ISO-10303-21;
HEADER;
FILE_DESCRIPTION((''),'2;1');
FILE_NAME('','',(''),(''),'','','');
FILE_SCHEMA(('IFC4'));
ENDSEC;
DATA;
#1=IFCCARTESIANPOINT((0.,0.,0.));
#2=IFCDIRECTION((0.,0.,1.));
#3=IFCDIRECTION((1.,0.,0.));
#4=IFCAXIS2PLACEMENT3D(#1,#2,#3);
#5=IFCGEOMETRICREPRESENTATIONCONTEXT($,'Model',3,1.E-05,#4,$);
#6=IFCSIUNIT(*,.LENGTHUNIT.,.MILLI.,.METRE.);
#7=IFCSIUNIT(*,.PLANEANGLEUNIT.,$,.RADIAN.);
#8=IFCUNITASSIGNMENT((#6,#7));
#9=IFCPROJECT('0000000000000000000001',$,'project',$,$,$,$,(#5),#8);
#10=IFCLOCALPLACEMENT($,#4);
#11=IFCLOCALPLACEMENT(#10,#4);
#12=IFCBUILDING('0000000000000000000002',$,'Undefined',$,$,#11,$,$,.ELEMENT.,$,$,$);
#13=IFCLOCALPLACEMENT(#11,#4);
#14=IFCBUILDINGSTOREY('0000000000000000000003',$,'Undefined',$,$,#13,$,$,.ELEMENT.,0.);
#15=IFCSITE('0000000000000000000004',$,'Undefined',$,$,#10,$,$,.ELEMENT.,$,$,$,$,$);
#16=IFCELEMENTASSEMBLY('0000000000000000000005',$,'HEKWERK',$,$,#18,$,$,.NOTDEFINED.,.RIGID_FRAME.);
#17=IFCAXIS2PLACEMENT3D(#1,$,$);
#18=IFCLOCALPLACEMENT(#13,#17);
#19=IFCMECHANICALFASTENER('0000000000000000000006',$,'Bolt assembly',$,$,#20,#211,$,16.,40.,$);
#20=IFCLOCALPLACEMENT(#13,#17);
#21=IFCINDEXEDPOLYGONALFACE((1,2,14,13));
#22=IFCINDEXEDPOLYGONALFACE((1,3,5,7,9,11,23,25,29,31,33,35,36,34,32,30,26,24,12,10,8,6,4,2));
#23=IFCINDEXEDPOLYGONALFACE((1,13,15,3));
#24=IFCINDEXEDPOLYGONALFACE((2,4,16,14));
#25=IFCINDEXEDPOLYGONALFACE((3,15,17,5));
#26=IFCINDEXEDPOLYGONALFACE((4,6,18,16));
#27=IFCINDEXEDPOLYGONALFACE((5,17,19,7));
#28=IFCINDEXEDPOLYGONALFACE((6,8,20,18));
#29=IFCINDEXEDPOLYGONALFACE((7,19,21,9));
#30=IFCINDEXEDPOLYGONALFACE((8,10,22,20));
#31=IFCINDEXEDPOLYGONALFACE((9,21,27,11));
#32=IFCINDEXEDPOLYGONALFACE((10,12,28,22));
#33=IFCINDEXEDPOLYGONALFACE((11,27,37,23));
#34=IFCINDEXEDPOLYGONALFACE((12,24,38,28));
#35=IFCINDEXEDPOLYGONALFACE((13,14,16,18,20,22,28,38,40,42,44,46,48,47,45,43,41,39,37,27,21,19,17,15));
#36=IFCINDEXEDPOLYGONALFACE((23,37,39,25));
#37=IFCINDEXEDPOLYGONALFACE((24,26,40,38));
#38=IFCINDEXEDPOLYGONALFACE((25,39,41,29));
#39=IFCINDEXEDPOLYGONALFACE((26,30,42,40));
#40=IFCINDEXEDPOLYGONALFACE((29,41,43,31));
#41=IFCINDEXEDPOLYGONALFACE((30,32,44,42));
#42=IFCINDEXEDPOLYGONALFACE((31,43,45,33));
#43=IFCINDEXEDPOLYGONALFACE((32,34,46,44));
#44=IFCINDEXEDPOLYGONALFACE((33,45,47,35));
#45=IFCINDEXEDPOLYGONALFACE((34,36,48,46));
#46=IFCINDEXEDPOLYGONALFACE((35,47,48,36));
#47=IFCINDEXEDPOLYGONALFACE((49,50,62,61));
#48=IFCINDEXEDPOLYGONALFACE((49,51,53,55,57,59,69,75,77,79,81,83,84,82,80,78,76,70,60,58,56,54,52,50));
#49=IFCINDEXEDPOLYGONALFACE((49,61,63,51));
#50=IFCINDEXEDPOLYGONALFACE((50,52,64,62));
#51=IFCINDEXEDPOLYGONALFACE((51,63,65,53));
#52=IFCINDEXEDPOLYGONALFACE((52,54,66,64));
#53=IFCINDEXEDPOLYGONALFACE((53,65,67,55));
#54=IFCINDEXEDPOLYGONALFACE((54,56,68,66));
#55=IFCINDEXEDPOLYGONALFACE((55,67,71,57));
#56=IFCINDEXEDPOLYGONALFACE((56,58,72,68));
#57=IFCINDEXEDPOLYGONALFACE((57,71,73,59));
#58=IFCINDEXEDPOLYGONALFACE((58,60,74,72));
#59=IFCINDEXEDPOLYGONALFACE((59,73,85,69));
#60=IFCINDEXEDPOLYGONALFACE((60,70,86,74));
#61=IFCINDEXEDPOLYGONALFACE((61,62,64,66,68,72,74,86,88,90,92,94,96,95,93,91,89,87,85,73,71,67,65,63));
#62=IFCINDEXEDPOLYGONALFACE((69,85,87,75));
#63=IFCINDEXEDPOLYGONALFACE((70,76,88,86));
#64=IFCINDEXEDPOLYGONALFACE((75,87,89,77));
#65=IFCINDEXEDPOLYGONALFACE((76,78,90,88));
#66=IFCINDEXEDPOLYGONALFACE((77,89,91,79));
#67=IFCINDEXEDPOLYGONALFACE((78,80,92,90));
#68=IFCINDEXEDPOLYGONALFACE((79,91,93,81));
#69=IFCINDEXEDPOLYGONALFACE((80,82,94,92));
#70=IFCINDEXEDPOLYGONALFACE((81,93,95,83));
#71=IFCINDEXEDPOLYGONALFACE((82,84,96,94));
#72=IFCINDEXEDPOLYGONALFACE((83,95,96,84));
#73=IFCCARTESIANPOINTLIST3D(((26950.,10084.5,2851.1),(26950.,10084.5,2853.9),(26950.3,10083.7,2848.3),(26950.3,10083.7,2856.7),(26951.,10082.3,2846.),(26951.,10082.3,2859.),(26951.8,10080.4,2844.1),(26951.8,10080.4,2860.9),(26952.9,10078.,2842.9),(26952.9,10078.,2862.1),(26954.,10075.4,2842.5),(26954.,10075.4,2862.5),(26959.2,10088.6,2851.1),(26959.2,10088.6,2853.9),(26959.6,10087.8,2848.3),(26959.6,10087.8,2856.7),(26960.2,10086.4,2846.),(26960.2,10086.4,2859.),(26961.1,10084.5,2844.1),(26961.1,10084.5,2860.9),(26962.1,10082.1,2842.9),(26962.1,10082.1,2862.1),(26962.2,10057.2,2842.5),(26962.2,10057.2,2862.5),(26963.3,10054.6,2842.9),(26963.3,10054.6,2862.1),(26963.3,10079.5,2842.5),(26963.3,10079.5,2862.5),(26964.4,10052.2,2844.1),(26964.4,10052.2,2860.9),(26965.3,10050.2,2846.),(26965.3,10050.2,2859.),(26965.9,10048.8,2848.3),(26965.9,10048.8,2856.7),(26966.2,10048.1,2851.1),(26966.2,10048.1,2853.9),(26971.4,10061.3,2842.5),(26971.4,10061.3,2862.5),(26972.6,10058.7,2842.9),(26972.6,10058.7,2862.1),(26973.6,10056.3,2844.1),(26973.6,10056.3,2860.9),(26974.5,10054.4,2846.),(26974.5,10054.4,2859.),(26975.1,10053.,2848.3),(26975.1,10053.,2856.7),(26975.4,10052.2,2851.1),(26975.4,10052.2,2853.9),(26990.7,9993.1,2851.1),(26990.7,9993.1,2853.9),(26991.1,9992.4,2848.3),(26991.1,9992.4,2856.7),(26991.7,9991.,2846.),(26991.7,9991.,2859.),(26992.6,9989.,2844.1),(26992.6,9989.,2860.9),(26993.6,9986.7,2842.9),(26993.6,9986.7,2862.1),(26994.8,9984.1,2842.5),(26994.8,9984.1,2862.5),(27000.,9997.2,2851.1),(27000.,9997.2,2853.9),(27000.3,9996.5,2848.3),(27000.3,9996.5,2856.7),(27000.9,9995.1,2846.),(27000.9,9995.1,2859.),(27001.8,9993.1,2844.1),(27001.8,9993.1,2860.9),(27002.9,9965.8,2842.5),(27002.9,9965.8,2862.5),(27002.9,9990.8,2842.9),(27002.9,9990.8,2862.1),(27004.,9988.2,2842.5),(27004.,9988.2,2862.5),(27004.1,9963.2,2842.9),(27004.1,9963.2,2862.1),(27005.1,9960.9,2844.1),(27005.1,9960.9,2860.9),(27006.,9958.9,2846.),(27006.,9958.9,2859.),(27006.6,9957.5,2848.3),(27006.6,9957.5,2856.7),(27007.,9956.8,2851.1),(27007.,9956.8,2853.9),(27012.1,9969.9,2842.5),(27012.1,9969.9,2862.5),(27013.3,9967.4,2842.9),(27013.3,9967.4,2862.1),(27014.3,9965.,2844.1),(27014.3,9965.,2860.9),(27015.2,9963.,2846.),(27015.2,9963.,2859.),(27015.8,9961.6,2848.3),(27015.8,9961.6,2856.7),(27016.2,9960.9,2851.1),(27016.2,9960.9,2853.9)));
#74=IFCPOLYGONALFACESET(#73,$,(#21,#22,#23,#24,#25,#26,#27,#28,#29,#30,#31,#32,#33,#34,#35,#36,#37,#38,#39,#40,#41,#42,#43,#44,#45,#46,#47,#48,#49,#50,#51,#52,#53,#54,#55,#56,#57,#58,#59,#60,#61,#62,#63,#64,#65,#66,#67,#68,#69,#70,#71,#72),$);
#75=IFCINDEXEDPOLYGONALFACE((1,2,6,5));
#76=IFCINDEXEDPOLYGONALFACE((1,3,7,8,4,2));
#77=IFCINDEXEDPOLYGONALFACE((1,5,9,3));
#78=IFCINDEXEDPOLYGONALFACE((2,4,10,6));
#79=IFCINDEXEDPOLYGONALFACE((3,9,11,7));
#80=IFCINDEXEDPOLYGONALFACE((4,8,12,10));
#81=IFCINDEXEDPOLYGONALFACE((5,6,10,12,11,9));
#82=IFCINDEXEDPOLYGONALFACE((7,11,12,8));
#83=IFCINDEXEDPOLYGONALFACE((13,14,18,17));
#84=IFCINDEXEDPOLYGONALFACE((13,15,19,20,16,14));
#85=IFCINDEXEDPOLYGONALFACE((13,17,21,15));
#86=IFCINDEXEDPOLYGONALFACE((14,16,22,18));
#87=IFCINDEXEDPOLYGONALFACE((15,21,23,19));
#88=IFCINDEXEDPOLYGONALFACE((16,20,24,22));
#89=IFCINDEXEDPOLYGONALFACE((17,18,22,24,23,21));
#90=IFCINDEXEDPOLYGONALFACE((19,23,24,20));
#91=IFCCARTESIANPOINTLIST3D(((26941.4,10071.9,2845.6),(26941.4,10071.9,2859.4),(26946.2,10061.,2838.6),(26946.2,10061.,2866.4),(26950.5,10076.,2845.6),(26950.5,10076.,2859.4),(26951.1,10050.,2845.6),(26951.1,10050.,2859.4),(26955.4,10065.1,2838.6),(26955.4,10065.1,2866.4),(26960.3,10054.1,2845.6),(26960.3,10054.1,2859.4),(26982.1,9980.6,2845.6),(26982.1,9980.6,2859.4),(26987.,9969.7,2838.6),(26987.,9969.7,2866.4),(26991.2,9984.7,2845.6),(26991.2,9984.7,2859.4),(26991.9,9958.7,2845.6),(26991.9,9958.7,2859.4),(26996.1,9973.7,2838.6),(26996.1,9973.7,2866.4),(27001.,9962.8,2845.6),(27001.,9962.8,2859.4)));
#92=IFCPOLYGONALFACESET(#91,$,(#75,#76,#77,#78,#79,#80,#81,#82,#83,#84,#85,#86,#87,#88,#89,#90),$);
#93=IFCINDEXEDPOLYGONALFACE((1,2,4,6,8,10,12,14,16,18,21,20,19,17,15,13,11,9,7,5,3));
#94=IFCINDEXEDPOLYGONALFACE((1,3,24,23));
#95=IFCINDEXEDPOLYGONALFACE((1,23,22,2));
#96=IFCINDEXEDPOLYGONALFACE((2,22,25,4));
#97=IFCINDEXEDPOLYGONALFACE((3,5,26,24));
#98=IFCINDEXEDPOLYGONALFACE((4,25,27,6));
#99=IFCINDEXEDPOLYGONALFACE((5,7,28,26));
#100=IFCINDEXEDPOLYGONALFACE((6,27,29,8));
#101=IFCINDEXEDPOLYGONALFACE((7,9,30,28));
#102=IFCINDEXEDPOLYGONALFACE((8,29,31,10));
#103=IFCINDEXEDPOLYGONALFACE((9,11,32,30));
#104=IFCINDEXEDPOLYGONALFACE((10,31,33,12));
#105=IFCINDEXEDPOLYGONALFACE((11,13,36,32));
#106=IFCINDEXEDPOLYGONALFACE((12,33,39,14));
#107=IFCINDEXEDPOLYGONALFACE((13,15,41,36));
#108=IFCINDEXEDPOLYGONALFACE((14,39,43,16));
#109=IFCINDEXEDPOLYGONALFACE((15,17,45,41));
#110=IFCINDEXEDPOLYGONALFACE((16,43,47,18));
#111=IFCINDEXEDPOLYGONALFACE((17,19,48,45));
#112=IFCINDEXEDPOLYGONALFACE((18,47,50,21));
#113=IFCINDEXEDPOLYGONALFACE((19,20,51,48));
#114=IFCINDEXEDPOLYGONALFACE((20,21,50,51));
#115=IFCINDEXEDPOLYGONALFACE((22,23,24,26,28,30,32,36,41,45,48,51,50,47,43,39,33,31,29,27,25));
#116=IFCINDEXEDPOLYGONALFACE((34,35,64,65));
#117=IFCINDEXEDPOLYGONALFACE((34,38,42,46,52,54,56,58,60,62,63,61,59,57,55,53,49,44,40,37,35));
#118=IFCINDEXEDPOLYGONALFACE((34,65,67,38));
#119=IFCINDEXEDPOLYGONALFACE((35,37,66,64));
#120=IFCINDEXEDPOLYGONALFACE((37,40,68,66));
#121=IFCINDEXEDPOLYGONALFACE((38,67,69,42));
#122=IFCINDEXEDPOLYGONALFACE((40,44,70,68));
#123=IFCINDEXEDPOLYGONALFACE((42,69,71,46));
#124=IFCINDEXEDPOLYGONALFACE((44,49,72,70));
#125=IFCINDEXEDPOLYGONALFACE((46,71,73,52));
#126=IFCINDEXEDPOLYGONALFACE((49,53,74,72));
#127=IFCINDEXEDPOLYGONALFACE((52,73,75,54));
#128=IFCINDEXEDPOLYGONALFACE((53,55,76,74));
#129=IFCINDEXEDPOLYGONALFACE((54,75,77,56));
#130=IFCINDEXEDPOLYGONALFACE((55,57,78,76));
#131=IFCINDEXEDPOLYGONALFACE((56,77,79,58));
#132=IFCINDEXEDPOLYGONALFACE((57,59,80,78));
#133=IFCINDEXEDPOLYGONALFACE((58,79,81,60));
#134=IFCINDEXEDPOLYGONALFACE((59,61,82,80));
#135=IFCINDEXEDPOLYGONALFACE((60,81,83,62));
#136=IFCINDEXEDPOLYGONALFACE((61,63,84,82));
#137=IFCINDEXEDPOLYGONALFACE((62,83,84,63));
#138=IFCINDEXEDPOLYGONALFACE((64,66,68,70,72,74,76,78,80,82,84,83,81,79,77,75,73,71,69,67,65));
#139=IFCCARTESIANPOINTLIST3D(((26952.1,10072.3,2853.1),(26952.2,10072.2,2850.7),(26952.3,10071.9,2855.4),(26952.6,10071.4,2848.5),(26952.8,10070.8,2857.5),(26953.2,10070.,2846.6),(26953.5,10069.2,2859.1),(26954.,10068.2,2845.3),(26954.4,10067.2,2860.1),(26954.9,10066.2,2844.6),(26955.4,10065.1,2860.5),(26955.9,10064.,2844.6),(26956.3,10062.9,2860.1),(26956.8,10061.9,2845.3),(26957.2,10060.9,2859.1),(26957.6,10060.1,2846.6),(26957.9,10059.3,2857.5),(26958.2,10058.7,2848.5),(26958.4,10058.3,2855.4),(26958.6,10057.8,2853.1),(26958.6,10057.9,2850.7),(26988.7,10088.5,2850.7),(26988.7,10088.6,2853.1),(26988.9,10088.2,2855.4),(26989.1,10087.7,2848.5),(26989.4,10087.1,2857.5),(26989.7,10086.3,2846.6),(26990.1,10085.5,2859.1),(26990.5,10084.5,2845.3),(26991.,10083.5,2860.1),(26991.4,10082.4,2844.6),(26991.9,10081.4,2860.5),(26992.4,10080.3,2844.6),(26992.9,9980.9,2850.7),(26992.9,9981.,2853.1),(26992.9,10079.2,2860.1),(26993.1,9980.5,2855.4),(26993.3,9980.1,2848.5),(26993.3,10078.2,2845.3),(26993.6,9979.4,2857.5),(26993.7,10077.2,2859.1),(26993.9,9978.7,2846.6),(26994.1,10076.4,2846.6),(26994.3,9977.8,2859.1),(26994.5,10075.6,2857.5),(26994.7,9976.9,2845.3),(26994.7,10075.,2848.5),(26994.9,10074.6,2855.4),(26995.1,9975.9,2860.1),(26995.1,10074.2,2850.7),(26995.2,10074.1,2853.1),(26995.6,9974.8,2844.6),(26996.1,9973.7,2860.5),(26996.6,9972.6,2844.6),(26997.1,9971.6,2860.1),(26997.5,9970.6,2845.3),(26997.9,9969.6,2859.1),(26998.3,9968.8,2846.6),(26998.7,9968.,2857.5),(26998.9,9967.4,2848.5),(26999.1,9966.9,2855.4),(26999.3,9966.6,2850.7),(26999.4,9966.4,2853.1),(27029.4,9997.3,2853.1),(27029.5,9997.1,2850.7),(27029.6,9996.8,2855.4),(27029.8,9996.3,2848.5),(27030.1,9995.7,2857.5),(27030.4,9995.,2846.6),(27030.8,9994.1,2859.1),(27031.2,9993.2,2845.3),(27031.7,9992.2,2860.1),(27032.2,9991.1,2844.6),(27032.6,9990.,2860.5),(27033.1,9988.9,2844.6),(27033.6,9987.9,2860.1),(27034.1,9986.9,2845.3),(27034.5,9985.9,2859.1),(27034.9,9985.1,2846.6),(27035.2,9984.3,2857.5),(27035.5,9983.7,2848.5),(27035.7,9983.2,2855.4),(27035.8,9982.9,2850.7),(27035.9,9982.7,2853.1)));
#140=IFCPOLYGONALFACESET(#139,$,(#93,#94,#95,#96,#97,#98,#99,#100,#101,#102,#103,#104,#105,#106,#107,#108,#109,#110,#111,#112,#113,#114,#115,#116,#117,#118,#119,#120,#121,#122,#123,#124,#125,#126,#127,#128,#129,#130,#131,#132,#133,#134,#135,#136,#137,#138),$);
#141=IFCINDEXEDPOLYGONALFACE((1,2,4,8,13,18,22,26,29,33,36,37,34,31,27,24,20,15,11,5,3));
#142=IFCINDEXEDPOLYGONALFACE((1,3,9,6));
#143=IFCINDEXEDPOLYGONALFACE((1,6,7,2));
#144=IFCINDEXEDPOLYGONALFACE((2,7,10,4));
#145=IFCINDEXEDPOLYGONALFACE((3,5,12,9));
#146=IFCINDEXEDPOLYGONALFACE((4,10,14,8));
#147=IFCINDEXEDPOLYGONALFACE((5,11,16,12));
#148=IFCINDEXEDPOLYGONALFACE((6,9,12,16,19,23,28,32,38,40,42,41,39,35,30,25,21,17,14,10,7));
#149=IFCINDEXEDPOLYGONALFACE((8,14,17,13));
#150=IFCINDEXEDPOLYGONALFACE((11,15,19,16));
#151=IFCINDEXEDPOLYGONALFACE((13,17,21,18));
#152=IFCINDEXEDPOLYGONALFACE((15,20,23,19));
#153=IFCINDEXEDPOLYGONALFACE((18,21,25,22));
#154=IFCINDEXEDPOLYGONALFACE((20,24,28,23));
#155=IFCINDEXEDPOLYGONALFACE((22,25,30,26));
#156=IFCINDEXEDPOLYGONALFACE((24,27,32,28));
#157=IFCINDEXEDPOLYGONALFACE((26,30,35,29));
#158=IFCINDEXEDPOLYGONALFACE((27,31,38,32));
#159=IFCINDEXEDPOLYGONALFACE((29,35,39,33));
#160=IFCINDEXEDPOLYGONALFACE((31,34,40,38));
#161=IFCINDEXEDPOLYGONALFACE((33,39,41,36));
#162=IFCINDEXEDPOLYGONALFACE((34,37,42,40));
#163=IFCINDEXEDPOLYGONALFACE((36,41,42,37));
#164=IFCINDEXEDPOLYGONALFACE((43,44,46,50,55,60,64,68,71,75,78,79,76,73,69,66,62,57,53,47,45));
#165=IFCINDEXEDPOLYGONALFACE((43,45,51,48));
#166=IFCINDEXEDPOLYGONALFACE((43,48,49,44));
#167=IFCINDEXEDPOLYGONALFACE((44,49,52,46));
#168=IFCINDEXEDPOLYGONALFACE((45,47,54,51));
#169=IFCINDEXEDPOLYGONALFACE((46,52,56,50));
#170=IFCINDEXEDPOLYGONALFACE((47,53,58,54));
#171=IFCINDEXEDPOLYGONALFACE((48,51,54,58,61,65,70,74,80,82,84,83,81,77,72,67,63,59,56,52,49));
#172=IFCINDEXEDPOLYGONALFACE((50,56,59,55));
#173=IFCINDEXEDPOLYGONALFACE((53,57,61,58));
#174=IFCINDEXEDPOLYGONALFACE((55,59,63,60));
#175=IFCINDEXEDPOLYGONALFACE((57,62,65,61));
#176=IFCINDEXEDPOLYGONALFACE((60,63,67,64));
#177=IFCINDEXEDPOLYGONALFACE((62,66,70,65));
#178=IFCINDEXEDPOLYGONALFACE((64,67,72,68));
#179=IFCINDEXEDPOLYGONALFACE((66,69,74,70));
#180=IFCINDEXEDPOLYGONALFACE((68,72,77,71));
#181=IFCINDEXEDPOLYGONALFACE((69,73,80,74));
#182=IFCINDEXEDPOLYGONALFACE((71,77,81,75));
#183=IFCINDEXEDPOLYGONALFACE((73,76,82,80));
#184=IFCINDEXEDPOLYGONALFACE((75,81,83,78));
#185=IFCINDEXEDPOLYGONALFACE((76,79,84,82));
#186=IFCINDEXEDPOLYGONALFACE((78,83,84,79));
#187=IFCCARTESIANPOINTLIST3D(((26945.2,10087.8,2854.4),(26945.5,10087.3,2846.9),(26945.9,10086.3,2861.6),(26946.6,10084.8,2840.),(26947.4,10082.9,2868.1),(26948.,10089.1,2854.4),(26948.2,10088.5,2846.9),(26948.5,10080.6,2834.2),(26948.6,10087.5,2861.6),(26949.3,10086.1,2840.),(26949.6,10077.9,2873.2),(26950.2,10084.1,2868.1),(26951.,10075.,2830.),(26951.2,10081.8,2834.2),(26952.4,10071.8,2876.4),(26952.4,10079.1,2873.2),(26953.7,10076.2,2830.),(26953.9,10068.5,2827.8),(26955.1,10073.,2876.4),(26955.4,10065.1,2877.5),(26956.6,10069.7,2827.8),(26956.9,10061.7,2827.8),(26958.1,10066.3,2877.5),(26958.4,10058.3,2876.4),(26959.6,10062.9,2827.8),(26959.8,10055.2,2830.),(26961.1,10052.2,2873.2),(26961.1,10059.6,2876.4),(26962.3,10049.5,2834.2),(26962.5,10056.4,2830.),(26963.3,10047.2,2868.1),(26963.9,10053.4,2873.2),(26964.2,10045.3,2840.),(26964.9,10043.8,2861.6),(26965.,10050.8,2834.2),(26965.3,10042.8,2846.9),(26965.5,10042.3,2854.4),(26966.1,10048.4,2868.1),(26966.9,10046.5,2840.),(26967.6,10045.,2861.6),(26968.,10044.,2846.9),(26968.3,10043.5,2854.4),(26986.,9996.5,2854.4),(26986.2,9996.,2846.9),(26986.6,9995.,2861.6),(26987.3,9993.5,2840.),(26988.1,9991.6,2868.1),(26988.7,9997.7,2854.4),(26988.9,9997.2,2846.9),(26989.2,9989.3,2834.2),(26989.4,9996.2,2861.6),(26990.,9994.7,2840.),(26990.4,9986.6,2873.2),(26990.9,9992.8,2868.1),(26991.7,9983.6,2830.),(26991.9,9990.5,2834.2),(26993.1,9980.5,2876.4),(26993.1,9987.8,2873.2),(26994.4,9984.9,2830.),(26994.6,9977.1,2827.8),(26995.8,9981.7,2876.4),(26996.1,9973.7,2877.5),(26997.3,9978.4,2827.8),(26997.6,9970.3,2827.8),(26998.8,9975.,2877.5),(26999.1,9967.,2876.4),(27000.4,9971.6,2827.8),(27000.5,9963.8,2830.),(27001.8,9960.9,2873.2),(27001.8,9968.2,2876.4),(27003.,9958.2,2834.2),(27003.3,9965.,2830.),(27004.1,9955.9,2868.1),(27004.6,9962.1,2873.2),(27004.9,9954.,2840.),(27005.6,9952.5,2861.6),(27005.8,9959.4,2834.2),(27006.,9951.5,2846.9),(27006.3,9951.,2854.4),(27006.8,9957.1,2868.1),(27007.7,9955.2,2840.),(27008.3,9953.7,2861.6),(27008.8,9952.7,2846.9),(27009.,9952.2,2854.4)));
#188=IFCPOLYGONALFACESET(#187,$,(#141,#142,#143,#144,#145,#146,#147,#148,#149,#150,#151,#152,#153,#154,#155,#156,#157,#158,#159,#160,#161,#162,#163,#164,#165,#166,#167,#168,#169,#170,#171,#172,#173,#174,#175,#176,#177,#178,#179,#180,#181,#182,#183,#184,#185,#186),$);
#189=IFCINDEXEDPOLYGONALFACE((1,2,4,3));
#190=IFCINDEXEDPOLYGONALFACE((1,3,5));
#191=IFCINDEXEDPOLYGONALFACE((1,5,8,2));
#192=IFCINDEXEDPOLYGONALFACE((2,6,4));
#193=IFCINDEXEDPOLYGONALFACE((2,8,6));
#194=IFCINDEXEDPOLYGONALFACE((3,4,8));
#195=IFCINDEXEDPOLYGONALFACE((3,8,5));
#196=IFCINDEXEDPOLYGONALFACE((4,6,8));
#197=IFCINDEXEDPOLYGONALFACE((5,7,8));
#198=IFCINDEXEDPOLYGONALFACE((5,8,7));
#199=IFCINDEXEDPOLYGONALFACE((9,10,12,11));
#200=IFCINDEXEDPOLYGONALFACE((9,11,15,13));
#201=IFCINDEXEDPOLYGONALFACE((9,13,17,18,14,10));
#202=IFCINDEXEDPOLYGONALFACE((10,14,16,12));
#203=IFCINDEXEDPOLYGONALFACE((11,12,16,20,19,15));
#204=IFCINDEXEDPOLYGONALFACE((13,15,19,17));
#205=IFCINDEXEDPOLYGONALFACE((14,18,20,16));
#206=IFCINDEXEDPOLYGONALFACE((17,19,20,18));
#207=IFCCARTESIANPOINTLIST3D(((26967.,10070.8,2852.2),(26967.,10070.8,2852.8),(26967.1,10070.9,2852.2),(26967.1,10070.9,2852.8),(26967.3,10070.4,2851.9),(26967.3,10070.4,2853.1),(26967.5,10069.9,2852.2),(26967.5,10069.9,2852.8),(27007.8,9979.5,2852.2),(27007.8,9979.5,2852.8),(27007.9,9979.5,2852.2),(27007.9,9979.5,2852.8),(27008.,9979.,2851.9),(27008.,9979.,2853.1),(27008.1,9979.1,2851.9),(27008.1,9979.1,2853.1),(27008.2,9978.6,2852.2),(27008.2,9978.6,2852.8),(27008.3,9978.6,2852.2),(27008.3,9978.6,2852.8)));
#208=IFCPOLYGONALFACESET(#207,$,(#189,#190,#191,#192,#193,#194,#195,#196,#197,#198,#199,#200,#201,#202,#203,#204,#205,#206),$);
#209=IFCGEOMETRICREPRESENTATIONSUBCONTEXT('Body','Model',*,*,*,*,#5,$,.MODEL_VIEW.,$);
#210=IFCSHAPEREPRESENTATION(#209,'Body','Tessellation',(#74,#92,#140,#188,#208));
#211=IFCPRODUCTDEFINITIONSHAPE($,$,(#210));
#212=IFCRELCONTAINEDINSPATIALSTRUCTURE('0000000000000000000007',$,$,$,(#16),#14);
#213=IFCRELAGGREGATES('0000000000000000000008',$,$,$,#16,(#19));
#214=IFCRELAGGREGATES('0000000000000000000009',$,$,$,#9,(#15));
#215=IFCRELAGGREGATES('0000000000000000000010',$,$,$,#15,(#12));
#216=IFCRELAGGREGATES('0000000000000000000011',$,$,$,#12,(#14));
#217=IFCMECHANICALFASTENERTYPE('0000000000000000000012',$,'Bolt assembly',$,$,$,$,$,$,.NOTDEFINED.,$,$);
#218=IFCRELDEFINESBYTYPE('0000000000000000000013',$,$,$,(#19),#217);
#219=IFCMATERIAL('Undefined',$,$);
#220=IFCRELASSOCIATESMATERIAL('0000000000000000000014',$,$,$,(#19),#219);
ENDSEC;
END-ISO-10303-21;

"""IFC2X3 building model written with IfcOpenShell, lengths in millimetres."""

from ifc_helpers import new_model, si_unit, frame, frame_2d, origin_with_axes, origin_2d_with_axis, place, context, subcontext, project, spatial, polyline, circle_curve, parameter, trimmed, segment, composite_curve, circle, outline, extrude, source, transform, mapped, material, type_object, element, aggregate, save


model = new_model("IFC2X3")

# Units and contexts
model_context = context("Model", 3, precision=1e-05, world=origin_with_axes())
body_context = subcontext(model_context, "Body", "Model", "MODEL_VIEW")
ifc_project = project(units=[si_unit("LENGTHUNIT", "METRE", prefix="MILLI"), si_unit("PLANEANGLEUNIT", "RADIAN")], contexts=[model_context])

# Site, building, storey
site_placement = place(None, origin_with_axes())
site = spatial("IfcSite", under=ifc_project, at=site_placement, Name="Undefined", CompositionType="ELEMENT")
building_placement = place(site_placement, origin_with_axes())
building = spatial("IfcBuilding", under=site, at=building_placement, Name="Undefined", CompositionType="ELEMENT")
storey_placement = place(building_placement, origin_with_axes())
storey = spatial("IfcBuildingStorey", under=building, at=storey_placement, Name="Undefined", CompositionType="ELEMENT", Elevation=0.0)

# Element assembly
assembly_1_placement = place(storey_placement, origin_with_axes())
assembly_1 = element("IfcElementAssembly", 1, at=assembly_1_placement, inside=storey, Name="HEKWERK", AssemblyPlace="NOTDEFINED", PredefinedType="RIGID_FRAME")

# Mechanical fastener
ifc_material_1 = material(Name="Undefined")
mechanical_fastener_type = type_object("IfcMechanicalFastenerType", Name="Bolt assembly")
shared_shape_1 = source(origin_with_axes(), body_context, "Body", "SweptSolid", [
    extrude(outline(composite_curve([segment(polyline([(10.0, 10.0), (10.0, -10.0)]), True, "CONTINUOUS"), segment(trimmed(circle_curve(frame_2d((0.0, -10.0), x_axis=(1.0, 0.0)), 10.0), [parameter(0.0)], [parameter(3.141593)], False, "PARAMETER"), True, "CONTINUOUS"), segment(polyline([(-10.0, -10.0), (-10.0, 10.0)]), True, "CONTINUOUS"), segment(trimmed(circle_curve(frame_2d((0.0, 10.0), x_axis=(-1.0, 0.0)), 10.0), [parameter(0.0)], [parameter(3.141593)], False, "PARAMETER"), True, "DISCONTINUOUS")], self_intersect=False)), frame((0.0, 30.0, 0.0), z_axis=(0.0, 1.0, 0.0), x_axis=(1.0, 0.0, 0.0)), (0.0, 0.0, 1.0), 10.1),
    extrude(outline(polyline([(13.9, 0.0), (6.9, 12.0), (-6.9, 12.0), (-13.9, 0.0), (-6.9, -12.0), (6.9, -12.0), (13.9, 0.0)])), frame((0.0, 17.0, 0.0), z_axis=(0.0, 1.0, 0.0), x_axis=(1.0, 0.0, 0.0)), (0.0, 0.0, 1.0), 10.0),
    extrude(circle(Radius=8.0, at=origin_2d_with_axis()), frame((0.0, 27.0, 0.0), z_axis=(0.0, 1.0, 0.0), x_axis=(1.0, 0.0, 0.0)), (0.0, 0.0, 1.0), 40.0),
    extrude(circle(Radius=25.0, at=origin_2d_with_axis()), frame((0.0, 27.0, 0.0), z_axis=(0.0, 1.0, 0.0), x_axis=(1.0, 0.0, 0.0)), (0.0, 0.0, 1.0), 3.0),
    extrude(outline(polyline([(0.6, 0.0), (0.3, 0.5), (-0.3, 0.5), (-0.6, 0.0), (-0.3, -0.5), (0.3, -0.5), (0.6, 0.0)])), frame((0.0, 40.0, 0.0), z_axis=(0.0, 1.0, 0.0), x_axis=(1.0, 0.0, 0.0)), (0.0, 0.0, 1.0), 0.1),
])
mechanical_fastener_1_placement = place(assembly_1_placement, frame((26951.1, 10008.4, 2852.5), z_axis=(-0.407268, 0.913309, 0.0), x_axis=(0.0, 0.0, 1.0)))
mechanical_fastener_1 = element("IfcMechanicalFastener", 2, at=mechanical_fastener_1_placement, type_object=mechanical_fastener_type, material=ifc_material_1, Name="Bolt assembly", NominalDiameter=16.0, NominalLength=40.0, context=body_context, shape_type="MappedRepresentation", body=[
    mapped(shared_shape_1, transform((0.0, 0.0, -50.0))),
    mapped(shared_shape_1, transform((0.0, 0.0, 50.0))),
])
aggregate(assembly_1, [mechanical_fastener_1])

save(model, "model.ifc")
